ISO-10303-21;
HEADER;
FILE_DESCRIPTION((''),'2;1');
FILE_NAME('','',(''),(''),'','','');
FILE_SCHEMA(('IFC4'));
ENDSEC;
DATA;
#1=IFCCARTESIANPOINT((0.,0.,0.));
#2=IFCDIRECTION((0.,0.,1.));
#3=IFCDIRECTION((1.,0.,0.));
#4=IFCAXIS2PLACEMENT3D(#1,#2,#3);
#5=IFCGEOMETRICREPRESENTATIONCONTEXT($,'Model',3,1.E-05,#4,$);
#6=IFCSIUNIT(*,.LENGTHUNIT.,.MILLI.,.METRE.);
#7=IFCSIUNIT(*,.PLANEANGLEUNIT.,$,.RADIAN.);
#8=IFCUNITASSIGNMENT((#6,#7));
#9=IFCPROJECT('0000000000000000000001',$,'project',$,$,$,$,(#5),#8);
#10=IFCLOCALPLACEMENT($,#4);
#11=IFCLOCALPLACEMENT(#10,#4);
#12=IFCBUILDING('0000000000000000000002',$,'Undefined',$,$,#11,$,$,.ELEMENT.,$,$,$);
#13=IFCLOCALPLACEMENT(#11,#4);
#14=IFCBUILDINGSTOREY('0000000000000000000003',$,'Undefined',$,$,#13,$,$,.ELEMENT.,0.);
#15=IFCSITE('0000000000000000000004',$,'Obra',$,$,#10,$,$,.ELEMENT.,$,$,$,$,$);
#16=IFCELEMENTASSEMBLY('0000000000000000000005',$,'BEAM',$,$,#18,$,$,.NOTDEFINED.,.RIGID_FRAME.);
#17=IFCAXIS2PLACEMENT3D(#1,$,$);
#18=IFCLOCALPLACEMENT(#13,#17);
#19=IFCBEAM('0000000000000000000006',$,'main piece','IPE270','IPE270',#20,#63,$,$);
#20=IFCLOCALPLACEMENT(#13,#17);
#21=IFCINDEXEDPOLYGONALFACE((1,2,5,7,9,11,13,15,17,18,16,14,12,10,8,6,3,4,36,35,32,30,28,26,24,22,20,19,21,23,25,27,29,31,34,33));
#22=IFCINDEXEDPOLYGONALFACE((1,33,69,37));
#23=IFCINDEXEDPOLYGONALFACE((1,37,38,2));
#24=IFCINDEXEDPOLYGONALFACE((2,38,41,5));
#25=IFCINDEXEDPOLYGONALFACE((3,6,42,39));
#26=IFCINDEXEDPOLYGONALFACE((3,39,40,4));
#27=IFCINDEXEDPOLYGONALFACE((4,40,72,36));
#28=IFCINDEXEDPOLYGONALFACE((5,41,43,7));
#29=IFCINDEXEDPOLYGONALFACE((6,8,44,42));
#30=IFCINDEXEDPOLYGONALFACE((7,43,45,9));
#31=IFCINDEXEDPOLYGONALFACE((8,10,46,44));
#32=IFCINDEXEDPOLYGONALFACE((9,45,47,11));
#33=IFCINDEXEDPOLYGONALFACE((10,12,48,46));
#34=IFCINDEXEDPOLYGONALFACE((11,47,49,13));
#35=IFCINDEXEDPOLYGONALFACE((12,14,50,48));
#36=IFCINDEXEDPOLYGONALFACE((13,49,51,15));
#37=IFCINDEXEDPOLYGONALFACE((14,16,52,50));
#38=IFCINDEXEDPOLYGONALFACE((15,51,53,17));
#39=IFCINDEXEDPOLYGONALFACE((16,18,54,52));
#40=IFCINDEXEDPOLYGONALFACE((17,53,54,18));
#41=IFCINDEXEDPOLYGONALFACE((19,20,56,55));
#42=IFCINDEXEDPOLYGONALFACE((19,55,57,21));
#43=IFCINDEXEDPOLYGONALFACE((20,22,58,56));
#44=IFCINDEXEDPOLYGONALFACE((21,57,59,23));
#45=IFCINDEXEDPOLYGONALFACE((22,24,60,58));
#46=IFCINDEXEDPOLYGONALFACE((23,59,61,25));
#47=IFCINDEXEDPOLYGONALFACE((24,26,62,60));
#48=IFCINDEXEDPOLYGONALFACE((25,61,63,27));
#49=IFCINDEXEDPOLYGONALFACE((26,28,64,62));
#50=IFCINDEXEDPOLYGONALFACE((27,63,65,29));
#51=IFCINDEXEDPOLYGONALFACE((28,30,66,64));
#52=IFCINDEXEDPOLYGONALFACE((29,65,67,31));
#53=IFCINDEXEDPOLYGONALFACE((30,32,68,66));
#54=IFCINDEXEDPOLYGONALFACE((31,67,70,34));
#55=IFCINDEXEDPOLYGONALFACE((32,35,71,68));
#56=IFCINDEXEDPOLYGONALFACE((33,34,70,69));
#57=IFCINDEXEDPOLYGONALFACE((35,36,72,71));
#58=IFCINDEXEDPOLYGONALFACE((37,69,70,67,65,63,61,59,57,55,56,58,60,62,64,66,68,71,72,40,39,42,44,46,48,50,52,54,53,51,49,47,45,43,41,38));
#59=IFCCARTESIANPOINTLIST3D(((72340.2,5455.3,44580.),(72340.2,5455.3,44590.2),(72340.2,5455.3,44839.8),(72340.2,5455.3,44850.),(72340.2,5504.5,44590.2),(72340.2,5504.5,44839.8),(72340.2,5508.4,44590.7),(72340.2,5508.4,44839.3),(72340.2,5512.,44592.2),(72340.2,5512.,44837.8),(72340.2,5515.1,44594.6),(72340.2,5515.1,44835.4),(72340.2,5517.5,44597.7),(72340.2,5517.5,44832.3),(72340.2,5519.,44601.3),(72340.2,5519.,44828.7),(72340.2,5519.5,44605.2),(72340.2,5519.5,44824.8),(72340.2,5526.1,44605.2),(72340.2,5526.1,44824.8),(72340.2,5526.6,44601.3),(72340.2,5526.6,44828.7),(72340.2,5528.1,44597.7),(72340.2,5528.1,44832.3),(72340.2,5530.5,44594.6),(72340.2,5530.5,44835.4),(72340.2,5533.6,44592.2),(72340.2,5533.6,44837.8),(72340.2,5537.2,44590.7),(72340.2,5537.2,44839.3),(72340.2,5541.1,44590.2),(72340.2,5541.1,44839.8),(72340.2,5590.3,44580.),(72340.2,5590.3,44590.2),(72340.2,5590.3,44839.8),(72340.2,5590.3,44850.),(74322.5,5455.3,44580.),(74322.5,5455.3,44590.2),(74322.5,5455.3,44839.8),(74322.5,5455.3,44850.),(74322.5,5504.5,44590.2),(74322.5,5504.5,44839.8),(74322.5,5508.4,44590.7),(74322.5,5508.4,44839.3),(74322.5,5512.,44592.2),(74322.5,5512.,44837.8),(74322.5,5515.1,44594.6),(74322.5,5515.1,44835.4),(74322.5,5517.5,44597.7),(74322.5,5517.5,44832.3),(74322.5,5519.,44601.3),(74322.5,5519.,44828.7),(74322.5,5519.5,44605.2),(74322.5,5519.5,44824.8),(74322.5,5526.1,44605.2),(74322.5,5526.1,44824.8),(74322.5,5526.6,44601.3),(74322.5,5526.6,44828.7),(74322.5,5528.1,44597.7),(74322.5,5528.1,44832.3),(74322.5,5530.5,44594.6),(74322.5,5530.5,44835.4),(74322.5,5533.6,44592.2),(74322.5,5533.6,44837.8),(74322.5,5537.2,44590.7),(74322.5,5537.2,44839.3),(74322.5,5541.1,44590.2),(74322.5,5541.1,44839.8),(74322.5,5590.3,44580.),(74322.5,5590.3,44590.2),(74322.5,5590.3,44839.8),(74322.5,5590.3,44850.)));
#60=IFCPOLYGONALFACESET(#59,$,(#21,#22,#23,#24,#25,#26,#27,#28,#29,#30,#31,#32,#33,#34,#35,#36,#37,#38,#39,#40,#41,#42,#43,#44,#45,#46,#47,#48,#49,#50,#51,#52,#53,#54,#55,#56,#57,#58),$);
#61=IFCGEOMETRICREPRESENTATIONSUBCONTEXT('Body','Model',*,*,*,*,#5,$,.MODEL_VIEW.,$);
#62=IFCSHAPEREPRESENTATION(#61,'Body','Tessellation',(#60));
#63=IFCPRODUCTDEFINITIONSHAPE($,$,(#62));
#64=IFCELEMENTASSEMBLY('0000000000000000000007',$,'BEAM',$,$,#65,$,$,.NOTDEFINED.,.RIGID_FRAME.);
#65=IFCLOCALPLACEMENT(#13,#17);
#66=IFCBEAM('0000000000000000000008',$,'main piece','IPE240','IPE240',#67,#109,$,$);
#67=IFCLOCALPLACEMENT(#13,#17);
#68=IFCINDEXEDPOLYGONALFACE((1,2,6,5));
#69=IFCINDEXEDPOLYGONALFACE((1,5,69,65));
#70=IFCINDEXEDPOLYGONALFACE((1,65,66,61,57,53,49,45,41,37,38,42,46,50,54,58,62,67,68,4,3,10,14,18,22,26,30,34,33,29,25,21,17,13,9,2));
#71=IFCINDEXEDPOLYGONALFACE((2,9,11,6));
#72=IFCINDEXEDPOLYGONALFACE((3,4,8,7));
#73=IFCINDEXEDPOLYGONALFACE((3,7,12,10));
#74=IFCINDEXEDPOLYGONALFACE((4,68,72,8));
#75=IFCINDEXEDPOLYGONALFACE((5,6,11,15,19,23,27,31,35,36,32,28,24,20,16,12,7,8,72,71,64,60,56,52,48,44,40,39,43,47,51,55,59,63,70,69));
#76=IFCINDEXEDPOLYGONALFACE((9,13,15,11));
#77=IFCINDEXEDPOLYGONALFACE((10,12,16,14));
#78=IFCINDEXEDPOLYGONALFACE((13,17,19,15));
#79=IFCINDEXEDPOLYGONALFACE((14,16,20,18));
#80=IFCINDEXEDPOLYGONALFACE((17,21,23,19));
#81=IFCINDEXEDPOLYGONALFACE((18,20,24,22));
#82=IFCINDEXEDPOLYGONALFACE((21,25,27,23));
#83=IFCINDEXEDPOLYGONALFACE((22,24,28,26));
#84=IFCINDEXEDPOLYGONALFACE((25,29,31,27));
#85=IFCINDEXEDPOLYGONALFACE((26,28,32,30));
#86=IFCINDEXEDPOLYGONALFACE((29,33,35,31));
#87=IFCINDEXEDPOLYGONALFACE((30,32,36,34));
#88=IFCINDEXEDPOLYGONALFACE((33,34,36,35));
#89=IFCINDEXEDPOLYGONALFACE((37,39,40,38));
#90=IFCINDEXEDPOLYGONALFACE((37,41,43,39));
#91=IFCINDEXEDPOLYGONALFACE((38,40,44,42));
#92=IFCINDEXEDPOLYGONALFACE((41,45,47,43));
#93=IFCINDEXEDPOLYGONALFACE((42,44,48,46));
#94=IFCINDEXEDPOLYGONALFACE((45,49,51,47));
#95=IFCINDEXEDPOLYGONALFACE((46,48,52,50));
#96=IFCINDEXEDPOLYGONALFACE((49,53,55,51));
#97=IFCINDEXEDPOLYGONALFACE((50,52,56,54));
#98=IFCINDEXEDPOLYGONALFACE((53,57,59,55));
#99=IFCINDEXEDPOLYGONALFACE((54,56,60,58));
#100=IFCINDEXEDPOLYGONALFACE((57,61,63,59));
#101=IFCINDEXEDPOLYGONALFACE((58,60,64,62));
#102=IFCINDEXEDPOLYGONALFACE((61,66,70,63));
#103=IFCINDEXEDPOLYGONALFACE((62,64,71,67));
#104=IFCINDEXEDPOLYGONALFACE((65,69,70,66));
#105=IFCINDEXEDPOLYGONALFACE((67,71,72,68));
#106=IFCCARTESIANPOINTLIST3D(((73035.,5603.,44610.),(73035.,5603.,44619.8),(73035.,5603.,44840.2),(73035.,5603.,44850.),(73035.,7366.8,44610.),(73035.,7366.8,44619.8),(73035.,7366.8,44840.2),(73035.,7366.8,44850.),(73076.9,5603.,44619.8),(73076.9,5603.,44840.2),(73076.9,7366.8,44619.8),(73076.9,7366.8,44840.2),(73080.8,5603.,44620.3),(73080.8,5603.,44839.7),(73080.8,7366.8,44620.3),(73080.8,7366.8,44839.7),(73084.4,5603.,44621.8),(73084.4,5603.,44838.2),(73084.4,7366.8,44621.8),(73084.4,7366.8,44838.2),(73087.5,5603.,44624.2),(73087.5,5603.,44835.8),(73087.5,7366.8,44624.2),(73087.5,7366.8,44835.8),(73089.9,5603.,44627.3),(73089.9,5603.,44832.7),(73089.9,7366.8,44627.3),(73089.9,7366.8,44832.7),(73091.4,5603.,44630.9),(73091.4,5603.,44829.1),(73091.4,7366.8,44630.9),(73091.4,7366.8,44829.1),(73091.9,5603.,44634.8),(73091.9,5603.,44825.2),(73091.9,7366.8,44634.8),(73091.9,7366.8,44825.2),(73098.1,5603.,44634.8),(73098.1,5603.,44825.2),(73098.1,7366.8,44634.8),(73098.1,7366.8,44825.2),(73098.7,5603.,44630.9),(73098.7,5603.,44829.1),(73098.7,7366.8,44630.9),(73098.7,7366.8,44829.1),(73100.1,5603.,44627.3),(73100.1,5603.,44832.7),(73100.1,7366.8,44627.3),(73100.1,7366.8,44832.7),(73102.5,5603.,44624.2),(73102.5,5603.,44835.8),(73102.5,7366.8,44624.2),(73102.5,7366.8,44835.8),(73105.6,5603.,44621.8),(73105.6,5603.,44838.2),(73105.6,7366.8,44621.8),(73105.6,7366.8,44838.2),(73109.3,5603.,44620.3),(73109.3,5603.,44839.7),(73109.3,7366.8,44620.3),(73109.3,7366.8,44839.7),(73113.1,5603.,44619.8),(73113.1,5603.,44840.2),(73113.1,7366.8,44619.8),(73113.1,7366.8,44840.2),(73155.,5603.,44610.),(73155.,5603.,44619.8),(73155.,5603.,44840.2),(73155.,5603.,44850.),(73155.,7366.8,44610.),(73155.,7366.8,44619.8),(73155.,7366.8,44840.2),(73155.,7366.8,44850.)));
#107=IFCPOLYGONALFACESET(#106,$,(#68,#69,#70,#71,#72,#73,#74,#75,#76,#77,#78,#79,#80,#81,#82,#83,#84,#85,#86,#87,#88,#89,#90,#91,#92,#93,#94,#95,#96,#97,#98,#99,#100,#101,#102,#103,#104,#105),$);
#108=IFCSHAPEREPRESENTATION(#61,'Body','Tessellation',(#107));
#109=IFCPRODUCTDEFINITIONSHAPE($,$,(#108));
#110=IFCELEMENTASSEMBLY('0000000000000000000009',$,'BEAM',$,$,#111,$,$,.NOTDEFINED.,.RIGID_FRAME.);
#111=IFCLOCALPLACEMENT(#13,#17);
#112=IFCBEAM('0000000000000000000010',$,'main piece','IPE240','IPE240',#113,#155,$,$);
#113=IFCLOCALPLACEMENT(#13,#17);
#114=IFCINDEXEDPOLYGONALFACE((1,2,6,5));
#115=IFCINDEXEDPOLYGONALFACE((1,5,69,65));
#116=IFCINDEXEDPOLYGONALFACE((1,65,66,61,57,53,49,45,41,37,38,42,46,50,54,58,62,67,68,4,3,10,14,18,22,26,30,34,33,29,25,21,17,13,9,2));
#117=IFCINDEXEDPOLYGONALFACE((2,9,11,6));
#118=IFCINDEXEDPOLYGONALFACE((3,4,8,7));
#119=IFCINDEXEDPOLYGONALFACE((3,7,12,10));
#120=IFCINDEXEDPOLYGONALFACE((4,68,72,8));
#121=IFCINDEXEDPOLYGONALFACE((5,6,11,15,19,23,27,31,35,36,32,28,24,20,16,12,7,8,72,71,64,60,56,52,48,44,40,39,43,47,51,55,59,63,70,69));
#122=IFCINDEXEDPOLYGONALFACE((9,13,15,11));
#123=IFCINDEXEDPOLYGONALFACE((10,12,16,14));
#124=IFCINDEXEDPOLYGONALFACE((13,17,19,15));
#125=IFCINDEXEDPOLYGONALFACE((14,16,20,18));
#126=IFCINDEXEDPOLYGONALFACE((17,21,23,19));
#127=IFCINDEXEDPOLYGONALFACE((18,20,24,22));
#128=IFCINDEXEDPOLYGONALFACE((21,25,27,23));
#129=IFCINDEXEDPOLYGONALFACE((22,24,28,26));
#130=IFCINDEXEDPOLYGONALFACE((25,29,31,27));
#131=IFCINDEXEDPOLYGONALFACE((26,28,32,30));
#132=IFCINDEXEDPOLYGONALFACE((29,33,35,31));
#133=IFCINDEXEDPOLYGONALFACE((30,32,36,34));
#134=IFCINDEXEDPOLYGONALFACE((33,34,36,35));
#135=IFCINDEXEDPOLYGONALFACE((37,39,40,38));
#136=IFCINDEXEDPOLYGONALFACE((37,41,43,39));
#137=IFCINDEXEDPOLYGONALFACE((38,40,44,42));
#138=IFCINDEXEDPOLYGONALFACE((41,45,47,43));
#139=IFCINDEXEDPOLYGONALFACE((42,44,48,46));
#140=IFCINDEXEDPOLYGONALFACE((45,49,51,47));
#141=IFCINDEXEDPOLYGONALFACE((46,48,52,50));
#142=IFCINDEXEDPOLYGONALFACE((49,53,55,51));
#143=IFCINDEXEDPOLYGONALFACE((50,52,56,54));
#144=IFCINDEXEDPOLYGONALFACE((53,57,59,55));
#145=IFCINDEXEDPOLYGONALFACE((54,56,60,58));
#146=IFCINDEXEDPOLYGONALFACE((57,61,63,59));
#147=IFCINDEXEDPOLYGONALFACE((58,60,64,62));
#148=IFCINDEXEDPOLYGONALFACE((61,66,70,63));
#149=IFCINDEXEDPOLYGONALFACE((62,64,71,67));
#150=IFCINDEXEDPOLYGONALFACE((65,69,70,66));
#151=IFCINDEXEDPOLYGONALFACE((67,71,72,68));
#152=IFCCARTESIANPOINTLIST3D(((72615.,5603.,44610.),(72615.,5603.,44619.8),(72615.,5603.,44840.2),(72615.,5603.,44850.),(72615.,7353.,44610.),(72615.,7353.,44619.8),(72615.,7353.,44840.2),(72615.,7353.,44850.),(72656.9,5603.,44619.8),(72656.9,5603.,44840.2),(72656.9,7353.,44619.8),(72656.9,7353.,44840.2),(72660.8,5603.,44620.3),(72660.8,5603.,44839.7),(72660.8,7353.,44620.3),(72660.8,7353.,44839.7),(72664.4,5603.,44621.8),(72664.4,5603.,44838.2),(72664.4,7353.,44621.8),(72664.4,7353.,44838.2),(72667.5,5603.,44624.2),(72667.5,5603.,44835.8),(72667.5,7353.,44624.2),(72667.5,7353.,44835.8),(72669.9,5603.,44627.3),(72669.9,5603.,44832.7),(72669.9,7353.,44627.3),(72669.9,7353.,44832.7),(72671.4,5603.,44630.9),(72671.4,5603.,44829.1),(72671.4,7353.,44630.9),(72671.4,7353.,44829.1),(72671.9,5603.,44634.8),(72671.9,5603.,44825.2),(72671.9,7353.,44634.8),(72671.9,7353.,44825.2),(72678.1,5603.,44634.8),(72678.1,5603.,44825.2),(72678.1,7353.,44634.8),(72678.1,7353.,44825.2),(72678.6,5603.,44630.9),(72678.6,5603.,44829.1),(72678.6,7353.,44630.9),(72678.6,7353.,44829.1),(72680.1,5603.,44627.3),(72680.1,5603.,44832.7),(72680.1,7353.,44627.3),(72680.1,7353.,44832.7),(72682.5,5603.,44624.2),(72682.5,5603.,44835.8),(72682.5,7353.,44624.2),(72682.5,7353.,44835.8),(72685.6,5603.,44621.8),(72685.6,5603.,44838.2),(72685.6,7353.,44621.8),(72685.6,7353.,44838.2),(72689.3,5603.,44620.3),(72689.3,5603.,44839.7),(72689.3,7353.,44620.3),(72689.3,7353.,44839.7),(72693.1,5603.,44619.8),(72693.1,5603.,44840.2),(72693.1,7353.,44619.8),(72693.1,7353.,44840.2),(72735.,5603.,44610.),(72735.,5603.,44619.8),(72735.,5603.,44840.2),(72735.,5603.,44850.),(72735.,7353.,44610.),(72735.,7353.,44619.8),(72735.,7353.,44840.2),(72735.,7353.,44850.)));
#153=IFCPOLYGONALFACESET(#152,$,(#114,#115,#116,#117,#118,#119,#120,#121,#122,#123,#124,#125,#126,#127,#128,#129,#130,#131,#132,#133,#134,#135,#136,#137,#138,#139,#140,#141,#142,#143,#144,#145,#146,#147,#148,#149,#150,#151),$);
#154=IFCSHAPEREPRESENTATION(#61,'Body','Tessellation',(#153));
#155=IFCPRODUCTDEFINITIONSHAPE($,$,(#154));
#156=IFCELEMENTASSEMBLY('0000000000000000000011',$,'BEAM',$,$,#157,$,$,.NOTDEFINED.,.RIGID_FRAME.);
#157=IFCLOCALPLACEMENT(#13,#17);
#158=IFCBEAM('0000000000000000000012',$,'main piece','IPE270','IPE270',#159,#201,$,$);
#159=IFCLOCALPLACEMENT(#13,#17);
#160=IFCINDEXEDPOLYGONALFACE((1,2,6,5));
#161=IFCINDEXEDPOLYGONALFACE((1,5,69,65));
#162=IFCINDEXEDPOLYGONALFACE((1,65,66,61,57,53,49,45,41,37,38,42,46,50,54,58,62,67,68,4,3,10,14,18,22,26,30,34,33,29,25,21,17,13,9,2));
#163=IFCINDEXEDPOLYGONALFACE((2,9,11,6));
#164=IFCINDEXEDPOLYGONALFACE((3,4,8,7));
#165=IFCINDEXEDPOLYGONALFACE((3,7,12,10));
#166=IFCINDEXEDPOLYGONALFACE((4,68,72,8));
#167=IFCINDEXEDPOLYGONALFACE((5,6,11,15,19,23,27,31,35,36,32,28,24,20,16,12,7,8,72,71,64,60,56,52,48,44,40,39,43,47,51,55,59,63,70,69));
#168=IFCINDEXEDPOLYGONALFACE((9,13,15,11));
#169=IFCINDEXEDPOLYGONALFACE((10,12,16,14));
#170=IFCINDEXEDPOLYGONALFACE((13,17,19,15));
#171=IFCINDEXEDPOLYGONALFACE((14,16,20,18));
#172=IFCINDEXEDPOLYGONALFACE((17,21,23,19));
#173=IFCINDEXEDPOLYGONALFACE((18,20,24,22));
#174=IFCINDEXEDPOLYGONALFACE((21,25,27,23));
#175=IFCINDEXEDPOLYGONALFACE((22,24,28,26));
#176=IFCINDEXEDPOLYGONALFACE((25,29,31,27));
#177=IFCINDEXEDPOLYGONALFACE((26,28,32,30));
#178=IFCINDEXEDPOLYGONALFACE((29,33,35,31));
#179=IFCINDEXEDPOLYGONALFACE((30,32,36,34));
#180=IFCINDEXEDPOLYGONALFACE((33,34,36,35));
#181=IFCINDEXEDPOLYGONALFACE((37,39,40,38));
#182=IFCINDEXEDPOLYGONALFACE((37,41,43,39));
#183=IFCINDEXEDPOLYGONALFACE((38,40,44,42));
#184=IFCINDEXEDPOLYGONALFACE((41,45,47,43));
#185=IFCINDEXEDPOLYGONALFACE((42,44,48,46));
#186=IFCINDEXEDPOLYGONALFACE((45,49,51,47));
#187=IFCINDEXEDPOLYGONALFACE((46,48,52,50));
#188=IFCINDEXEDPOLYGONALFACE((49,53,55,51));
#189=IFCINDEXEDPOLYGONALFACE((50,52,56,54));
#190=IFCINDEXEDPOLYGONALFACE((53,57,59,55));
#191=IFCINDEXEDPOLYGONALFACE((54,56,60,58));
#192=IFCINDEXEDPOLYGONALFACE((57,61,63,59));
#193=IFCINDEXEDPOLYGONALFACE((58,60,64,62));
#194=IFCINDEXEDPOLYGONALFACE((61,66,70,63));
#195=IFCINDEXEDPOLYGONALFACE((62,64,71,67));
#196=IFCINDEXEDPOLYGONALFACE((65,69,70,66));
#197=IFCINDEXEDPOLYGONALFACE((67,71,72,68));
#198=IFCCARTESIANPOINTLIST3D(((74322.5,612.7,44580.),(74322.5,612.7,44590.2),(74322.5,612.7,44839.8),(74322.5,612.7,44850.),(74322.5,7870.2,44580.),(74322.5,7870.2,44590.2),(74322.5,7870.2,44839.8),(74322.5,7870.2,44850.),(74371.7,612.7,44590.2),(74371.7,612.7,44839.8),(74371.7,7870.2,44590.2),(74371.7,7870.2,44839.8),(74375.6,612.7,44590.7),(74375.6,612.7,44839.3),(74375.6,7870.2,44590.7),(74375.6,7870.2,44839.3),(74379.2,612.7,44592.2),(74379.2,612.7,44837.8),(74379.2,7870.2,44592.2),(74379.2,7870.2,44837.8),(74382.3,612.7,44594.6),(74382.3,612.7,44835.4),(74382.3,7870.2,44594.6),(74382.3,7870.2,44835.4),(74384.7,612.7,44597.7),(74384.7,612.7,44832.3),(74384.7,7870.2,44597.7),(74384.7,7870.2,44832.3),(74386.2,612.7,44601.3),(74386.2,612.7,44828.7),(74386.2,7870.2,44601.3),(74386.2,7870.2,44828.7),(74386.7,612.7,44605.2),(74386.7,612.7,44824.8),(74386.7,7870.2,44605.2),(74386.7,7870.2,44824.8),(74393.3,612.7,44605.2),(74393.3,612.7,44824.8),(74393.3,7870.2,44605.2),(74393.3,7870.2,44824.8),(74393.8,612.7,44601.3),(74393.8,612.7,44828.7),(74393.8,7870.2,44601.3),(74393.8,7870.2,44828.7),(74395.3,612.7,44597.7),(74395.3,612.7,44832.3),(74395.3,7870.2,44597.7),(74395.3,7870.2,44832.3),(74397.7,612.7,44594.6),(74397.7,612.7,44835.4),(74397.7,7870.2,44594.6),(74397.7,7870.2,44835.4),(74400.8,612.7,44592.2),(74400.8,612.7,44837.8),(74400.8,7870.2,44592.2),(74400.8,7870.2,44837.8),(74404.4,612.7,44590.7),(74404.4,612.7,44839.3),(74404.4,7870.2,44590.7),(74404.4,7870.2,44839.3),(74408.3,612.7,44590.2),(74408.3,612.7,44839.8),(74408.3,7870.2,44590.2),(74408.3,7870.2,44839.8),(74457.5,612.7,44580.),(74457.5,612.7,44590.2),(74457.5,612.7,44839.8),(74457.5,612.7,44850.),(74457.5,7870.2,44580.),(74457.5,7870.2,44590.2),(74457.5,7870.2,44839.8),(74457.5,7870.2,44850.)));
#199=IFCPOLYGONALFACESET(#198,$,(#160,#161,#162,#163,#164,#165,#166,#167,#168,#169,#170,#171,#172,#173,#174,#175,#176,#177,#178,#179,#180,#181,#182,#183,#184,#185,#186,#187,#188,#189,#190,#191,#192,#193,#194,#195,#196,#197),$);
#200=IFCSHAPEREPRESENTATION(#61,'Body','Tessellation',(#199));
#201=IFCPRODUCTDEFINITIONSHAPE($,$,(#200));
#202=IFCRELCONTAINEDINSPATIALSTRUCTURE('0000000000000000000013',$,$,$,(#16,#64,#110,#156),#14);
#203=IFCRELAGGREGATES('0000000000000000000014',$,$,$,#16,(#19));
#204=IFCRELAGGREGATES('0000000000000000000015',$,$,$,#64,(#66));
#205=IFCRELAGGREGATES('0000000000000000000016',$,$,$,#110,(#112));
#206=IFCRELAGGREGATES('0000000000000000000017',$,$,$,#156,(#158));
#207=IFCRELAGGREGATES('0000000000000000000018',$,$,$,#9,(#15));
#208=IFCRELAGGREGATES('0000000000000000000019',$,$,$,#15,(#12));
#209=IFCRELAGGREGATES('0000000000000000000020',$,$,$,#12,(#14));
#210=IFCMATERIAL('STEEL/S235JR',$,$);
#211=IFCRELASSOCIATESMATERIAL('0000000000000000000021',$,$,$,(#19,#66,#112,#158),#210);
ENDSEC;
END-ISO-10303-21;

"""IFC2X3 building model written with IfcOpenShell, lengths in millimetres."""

from ifc_helpers import new_model, si_unit, frame, origin_with_axes, origin_2d_with_axis, place, context, subcontext, project, spatial, i_section, extrude, material, element, aggregate, save


model = new_model("IFC2X3")

# Units and contexts
model_context = context("Model", 3, precision=1e-05, world=origin_with_axes())
body_context = subcontext(model_context, "Body", "Model", "MODEL_VIEW")
ifc_project = project(units=[si_unit("LENGTHUNIT", "METRE", prefix="MILLI"), si_unit("PLANEANGLEUNIT", "RADIAN")], contexts=[model_context])

# Site, building, storey
site_placement = place(None, origin_with_axes())
site = spatial("IfcSite", under=ifc_project, at=site_placement, Name="Obra", CompositionType="ELEMENT")
building_placement = place(site_placement, origin_with_axes())
building = spatial("IfcBuilding", under=site, at=building_placement, Name="Undefined", CompositionType="ELEMENT")
storey_placement = place(building_placement, origin_with_axes())
storey = spatial("IfcBuildingStorey", under=building, at=storey_placement, Name="Undefined", CompositionType="ELEMENT", Elevation=0.0)

# Element assemblies, beams
ifc_material_1 = material(Name="STEEL/S235JR")
assembly_1_placement = place(storey_placement, origin_with_axes())
assembly_1 = element("IfcElementAssembly", 1, at=assembly_1_placement, inside=storey, Name="BEAM", AssemblyPlace="NOTDEFINED", PredefinedType="RIGID_FRAME")
beam_1_placement = place(assembly_1_placement, frame((72340.2, 5522.8, 44715.0), z_axis=(0.0, 0.0, 1.0), x_axis=(1.0, 0.0, 0.0)))
beam_1 = element("IfcBeam", 2, at=beam_1_placement, material=ifc_material_1, Name="main piece", Description="IPE270", ObjectType="IPE270", context=body_context, shape_type="SweptSolid", body=[
    extrude(i_section(OverallWidth=135.0, OverallDepth=270.0, WebThickness=6.6, FlangeThickness=10.2, FilletRadius=15.0, at=origin_2d_with_axis()), frame((1982.3, 0.0, 0.0), z_axis=(-1.0, 0.0, 0.0), x_axis=(0.0, -1.0, 0.0)), (0.0, 0.0, 1.0), 1982.3),
])
aggregate(assembly_1, [beam_1])
assembly_2_placement = place(storey_placement, origin_with_axes())
assembly_2 = element("IfcElementAssembly", 3, at=assembly_2_placement, inside=storey, Name="BEAM", AssemblyPlace="NOTDEFINED", PredefinedType="RIGID_FRAME")
beam_2_placement = place(assembly_2_placement, frame((73095.0, 7366.8, 44730.0), z_axis=(0.0, 0.0, 1.0), x_axis=(0.0, -1.0, 0.0)))
beam_2 = element("IfcBeam", 4, at=beam_2_placement, material=ifc_material_1, Name="main piece", Description="IPE240", ObjectType="IPE240", context=body_context, shape_type="SweptSolid", body=[
    extrude(i_section(OverallWidth=120.0, OverallDepth=240.0, WebThickness=6.2, FlangeThickness=9.8, FilletRadius=15.0, at=origin_2d_with_axis()), frame((1763.8, 0.0, 0.0), z_axis=(-1.0, 0.0, 0.0), x_axis=(0.0, -1.0, 0.0)), (0.0, 0.0, 1.0), 1763.8),
])
aggregate(assembly_2, [beam_2])
assembly_3_placement = place(storey_placement, origin_with_axes())
assembly_3 = element("IfcElementAssembly", 5, at=assembly_3_placement, inside=storey, Name="BEAM", AssemblyPlace="NOTDEFINED", PredefinedType="RIGID_FRAME")
beam_3_placement = place(assembly_3_placement, frame((72675.0, 5603.0, 44730.0), z_axis=(0.0, 0.0, 1.0), x_axis=(0.0, 1.0, 0.0)))
beam_3 = element("IfcBeam", 6, at=beam_3_placement, material=ifc_material_1, Name="main piece", Description="IPE240", ObjectType="IPE240", context=body_context, shape_type="SweptSolid", body=[
    extrude(i_section(OverallWidth=120.0, OverallDepth=240.0, WebThickness=6.2, FlangeThickness=9.8, FilletRadius=15.0, at=origin_2d_with_axis()), frame((1750.0, 0.0, 0.0), z_axis=(-1.0, 0.0, 0.0), x_axis=(0.0, -1.0, 0.0)), (0.0, 0.0, 1.0), 1750.0),
])
aggregate(assembly_3, [beam_3])
assembly_4_placement = place(storey_placement, origin_with_axes())
assembly_4 = element("IfcElementAssembly", 7, at=assembly_4_placement, inside=storey, Name="BEAM", AssemblyPlace="NOTDEFINED", PredefinedType="RIGID_FRAME")
beam_4_placement = place(assembly_4_placement, frame((74390.0, 612.7, 44715.0), z_axis=(0.0, 0.0, 1.0), x_axis=(0.0, 1.0, 0.0)))
beam_4 = element("IfcBeam", 8, at=beam_4_placement, material=ifc_material_1, Name="main piece", Description="IPE270", ObjectType="IPE270", context=body_context, shape_type="SweptSolid", body=[
    extrude(i_section(OverallWidth=135.0, OverallDepth=270.0, WebThickness=6.6, FlangeThickness=10.2, FilletRadius=15.0, at=origin_2d_with_axis()), frame((7257.5, 0.0, 0.0), z_axis=(-1.0, 0.0, 0.0), x_axis=(0.0, -1.0, 0.0)), (0.0, 0.0, 1.0), 7257.5),
])
aggregate(assembly_4, [beam_4])

save(model, "model.ifc")
